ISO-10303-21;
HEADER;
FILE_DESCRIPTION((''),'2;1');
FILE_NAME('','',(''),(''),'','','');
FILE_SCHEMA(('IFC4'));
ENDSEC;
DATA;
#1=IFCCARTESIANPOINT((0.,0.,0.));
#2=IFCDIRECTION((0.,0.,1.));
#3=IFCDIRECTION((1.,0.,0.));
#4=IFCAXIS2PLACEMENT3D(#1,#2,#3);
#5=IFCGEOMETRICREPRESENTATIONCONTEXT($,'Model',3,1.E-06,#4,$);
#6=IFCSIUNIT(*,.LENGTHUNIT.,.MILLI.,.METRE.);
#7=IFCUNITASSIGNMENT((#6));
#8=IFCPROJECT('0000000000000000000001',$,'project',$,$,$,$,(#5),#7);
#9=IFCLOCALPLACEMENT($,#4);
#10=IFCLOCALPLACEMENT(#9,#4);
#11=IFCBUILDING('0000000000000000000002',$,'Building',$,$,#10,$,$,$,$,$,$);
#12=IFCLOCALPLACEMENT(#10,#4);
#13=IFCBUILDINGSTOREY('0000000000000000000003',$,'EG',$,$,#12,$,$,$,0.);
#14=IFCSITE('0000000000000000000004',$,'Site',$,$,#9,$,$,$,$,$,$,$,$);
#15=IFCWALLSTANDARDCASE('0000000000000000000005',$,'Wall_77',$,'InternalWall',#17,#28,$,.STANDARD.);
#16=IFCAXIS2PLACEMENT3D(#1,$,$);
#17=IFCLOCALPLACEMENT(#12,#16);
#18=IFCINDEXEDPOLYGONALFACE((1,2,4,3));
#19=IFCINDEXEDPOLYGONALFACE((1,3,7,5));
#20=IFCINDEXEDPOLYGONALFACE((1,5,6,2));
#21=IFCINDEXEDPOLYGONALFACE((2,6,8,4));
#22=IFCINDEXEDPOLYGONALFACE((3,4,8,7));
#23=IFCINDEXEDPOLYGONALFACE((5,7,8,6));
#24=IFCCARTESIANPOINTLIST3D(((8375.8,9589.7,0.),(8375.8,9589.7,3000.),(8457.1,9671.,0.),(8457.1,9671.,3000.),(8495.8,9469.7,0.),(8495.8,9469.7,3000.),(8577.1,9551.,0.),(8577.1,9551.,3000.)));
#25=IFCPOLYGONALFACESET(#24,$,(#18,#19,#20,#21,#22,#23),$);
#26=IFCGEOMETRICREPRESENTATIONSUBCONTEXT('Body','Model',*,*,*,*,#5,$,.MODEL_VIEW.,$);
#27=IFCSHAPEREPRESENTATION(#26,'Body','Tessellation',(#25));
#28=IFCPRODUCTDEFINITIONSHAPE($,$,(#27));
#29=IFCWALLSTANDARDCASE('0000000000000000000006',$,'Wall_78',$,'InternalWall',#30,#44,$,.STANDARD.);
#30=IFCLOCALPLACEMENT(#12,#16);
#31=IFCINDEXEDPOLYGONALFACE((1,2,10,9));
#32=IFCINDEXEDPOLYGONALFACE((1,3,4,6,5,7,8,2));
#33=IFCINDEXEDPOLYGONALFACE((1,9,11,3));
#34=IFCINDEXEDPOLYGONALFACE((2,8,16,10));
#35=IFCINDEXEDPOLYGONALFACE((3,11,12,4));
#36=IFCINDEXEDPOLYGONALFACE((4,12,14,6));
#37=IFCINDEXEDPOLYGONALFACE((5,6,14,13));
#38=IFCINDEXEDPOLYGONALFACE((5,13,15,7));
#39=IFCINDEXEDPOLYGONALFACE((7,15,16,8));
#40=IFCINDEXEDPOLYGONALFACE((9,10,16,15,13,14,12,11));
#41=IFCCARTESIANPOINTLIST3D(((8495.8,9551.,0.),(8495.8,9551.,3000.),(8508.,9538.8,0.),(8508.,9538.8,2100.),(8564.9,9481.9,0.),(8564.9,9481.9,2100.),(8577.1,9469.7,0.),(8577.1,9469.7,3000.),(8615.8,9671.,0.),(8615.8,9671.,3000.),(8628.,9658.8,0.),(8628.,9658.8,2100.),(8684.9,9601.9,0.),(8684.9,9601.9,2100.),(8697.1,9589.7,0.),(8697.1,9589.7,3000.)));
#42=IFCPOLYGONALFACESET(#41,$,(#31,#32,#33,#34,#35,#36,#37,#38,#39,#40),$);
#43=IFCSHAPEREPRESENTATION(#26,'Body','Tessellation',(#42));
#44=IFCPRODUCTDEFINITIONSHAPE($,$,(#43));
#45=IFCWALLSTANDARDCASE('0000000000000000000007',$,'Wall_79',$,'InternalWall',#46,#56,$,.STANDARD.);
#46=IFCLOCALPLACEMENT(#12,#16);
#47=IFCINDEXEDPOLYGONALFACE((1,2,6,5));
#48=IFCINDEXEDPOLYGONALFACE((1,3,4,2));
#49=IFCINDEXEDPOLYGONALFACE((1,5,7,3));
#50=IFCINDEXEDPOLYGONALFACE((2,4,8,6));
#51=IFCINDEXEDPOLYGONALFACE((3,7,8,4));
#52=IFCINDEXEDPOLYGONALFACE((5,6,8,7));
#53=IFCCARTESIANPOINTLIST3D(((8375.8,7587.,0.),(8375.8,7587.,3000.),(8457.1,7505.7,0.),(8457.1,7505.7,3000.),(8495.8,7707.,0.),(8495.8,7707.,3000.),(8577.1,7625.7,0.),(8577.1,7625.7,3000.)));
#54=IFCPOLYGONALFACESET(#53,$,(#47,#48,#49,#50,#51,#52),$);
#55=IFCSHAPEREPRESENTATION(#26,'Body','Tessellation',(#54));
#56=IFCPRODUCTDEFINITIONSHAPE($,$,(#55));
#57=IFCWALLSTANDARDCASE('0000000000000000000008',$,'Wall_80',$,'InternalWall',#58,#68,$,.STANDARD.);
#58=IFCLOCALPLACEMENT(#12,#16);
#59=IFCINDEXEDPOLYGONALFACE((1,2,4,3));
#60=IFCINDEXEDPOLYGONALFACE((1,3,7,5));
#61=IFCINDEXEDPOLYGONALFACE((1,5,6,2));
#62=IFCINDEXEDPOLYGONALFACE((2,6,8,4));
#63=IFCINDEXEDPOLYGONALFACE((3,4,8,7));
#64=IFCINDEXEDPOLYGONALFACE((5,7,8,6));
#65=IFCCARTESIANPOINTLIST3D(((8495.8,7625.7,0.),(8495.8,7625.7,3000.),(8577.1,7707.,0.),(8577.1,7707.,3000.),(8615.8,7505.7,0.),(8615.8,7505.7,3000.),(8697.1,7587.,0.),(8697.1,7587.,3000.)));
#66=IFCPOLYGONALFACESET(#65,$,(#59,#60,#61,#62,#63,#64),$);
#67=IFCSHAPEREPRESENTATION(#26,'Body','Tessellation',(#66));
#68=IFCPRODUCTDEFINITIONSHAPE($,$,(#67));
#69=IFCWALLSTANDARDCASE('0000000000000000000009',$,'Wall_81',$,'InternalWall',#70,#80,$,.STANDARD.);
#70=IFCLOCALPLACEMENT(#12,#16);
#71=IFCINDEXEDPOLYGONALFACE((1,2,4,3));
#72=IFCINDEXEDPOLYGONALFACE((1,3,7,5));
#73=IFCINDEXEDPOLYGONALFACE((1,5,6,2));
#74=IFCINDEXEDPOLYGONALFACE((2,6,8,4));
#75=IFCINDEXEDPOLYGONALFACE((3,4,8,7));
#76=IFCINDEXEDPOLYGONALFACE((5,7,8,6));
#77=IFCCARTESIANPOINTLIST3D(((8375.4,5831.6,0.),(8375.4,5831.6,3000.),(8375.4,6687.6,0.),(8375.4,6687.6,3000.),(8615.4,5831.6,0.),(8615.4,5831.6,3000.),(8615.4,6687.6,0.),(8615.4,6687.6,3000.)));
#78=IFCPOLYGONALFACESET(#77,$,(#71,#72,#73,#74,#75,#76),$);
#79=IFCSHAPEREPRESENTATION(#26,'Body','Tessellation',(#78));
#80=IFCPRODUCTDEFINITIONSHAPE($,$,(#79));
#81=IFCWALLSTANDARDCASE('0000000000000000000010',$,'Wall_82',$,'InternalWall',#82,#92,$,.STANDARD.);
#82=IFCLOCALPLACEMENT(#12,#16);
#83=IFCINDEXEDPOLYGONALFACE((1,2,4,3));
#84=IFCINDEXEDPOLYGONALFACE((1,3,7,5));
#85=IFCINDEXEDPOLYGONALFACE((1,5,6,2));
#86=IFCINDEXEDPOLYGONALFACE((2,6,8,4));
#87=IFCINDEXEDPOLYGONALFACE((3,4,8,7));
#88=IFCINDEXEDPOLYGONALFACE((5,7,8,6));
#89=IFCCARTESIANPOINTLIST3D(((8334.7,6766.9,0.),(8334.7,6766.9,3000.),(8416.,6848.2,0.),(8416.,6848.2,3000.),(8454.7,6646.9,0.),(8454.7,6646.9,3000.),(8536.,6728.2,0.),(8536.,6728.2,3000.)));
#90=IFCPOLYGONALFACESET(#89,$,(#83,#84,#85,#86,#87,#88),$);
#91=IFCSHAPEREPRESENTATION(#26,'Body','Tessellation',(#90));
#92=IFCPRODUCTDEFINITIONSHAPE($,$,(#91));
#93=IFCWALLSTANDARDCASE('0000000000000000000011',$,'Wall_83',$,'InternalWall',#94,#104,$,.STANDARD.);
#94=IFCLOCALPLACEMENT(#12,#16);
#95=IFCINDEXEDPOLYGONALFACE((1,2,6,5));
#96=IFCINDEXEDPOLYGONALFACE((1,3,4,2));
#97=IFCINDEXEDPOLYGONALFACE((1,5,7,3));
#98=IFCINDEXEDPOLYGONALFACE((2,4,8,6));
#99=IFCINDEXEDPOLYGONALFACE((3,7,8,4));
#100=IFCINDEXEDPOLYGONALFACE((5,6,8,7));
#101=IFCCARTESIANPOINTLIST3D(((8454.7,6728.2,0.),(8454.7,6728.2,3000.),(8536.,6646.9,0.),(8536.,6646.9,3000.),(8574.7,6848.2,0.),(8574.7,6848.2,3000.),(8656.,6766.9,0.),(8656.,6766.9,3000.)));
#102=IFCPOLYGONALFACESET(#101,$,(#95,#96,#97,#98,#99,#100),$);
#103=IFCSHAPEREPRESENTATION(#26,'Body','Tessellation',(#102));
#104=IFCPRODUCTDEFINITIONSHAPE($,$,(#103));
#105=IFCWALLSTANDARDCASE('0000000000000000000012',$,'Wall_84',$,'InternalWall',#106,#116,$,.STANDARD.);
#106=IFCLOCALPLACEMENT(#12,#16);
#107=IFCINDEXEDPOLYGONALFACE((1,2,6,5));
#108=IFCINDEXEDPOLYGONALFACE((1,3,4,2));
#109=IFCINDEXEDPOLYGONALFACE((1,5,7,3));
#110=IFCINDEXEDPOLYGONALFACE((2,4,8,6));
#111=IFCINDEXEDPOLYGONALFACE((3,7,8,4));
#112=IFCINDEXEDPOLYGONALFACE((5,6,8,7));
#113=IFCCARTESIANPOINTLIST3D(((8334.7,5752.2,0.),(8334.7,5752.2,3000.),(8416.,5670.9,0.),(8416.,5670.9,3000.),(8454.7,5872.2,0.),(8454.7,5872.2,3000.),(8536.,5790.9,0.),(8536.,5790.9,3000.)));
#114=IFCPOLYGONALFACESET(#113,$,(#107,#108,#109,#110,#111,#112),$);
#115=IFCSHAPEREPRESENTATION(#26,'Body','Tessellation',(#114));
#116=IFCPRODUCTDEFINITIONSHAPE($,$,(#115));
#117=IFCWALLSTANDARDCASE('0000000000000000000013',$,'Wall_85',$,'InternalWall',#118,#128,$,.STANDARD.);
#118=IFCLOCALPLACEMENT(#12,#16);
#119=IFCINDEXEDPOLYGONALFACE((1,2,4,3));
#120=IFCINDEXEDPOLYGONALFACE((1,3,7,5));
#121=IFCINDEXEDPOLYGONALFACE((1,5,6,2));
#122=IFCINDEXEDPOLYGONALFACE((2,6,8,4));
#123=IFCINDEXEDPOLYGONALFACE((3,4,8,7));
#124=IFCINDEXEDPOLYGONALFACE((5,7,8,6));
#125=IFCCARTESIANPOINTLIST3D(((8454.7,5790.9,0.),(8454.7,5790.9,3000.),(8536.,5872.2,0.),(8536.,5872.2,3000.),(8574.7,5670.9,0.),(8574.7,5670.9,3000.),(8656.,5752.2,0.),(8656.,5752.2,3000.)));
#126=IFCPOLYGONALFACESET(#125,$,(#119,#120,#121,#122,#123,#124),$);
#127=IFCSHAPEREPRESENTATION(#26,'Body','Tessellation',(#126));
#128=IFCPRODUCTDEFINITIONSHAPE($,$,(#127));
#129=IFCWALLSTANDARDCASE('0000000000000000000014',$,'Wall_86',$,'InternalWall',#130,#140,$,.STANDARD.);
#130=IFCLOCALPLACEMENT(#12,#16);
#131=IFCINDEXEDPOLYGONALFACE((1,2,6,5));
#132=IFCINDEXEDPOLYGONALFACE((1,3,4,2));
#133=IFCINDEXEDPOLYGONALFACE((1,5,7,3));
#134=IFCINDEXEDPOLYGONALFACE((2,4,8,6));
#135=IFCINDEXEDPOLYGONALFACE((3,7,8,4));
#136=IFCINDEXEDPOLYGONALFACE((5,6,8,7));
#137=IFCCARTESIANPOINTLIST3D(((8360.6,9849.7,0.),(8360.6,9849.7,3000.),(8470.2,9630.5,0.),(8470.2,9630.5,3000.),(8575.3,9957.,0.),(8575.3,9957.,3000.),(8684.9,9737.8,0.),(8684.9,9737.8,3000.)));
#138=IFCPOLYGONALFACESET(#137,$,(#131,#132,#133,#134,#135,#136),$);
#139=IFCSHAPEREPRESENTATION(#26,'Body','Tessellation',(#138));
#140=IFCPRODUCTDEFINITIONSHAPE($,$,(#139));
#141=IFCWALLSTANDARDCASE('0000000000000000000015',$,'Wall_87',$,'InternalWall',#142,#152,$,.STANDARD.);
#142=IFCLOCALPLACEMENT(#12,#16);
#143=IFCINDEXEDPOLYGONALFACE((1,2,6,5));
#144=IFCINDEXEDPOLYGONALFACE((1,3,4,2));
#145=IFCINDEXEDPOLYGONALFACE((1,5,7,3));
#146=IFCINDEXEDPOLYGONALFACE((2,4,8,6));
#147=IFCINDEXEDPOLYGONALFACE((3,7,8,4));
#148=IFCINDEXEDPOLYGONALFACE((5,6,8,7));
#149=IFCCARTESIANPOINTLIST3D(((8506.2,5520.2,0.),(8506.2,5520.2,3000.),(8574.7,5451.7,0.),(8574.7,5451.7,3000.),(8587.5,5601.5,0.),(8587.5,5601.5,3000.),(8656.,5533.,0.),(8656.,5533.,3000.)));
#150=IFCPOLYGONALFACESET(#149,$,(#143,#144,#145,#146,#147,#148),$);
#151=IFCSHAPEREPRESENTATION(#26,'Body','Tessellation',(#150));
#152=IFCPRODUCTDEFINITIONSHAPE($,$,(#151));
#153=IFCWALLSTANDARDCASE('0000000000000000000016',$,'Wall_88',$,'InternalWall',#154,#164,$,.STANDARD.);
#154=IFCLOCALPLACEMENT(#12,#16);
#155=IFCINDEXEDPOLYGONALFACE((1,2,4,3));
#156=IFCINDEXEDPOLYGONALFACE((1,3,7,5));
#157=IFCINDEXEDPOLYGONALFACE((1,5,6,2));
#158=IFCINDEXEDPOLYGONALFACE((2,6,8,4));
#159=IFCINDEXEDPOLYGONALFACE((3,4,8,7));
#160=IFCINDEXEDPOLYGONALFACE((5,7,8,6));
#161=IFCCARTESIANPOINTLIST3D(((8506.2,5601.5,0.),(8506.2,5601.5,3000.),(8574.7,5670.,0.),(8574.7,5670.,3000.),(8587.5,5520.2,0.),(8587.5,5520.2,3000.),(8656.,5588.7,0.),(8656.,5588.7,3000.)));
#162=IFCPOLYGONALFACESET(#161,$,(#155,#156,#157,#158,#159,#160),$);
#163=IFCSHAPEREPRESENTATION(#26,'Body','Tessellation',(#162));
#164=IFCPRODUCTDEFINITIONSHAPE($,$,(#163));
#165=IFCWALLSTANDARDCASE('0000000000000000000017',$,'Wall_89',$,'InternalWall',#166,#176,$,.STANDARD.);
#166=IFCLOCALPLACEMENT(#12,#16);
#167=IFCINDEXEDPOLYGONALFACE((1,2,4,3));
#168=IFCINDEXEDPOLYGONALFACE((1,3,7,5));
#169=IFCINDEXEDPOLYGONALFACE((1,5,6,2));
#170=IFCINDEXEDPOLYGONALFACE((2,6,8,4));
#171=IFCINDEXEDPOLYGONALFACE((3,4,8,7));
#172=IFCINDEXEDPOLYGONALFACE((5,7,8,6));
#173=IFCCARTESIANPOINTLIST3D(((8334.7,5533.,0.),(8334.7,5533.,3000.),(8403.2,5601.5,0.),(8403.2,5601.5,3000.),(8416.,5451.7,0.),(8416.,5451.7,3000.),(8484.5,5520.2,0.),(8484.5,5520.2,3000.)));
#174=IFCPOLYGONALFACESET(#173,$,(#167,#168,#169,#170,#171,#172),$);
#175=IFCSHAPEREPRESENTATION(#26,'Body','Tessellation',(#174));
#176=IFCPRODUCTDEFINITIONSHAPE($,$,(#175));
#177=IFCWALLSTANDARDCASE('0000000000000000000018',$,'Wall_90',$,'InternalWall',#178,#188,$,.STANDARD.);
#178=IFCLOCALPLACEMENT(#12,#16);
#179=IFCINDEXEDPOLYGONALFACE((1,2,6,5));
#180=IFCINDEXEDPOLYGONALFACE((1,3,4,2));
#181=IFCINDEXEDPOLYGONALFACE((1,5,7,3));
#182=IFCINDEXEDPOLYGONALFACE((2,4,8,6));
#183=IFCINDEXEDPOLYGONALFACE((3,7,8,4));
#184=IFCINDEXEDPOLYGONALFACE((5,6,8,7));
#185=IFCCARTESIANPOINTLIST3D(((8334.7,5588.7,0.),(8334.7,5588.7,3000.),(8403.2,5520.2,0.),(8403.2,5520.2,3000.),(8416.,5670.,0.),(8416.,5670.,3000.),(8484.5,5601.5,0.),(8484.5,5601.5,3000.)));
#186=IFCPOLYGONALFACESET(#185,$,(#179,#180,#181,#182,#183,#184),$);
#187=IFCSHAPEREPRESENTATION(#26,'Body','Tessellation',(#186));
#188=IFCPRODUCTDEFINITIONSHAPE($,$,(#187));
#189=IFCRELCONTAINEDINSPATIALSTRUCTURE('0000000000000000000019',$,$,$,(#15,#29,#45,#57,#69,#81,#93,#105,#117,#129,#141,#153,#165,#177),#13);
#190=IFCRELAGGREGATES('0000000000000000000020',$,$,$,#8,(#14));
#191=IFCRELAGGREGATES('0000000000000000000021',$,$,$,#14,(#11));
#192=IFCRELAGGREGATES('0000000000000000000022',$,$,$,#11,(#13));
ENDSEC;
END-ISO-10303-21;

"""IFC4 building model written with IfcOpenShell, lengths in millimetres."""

from ifc_helpers import new_model, si_unit, frame, origin_with_axes, place, context, subcontext, project, spatial, rectangle, extrude, element, save


model = new_model("IFC4")

# Units and contexts
model_context = context("Model", 3, precision=1e-06, world=origin_with_axes())
body_context = subcontext(model_context, "Body", "Model", "MODEL_VIEW")
ifc_project = project(units=[si_unit("LENGTHUNIT", "METRE", prefix="MILLI")], contexts=[model_context])

# Site, building, storey
site_placement = place(None, origin_with_axes())
site = spatial("IfcSite", under=ifc_project, at=site_placement, Name="Site")
building_placement = place(site_placement, origin_with_axes())
building = spatial("IfcBuilding", under=site, at=building_placement, Name="Building")
storey_placement = place(building_placement, origin_with_axes())
storey = spatial("IfcBuildingStorey", under=building, at=storey_placement, Name="EG", Elevation=0.0)

# Wall
wall_1_placement = place(storey_placement, origin_with_axes())
element("IfcWallStandardCase", 1, at=wall_1_placement, inside=storey, Name="Wall_77", ObjectType="InternalWall", PredefinedType="STANDARD", context=body_context, shape_type="SweptSolid", body=[
    extrude(rectangle(XDim=169.7, YDim=115.0), frame((8476.5, 9570.4, 0.0), z_axis=(0.0, 0.0, 1.0), x_axis=(-0.707107, 0.707107, 0.0)), (0.0, 0.0, 1.0), 3000.0),
])

# Wall, opening
wall_2_placement = place(storey_placement, origin_with_axes())
wall_2 = element("IfcWallStandardCase", 2, at=wall_2_placement, inside=storey, Name="Wall_78", ObjectType="InternalWall", PredefinedType="STANDARD", context=body_context, shape_type="SweptSolid", body=[
    extrude(rectangle(XDim=169.7, YDim=115.0), frame((8596.5, 9570.4, 0.0), z_axis=(0.0, 0.0, 1.0), x_axis=(0.707107, 0.707107, 0.0)), (0.0, 0.0, 1.0), 3000.0),
])
opening_1_placement = place(wall_2_placement, origin_with_axes())
element("IfcOpeningElement", 3, at=opening_1_placement, inside=storey, cuts=wall_2, context=body_context, shape_type="SweptSolid", body=[
    extrude(rectangle(XDim=1067.6, YDim=80.5), frame((8894.2, 9868.0, 0.0), z_axis=(0.0, 0.0, 1.0), x_axis=(0.707107, 0.707107, 0.0)), (0.0, 0.0, 1.0), 2100.0),
])

# Walls
wall_3_placement = place(storey_placement, origin_with_axes())
element("IfcWallStandardCase", 4, at=wall_3_placement, inside=storey, Name="Wall_79", ObjectType="InternalWall", PredefinedType="STANDARD", context=body_context, shape_type="SweptSolid", body=[
    extrude(rectangle(XDim=169.7, YDim=115.0), frame((8476.5, 7606.4, 0.0), z_axis=(0.0, 0.0, 1.0), x_axis=(-0.707107, -0.707107, 0.0)), (0.0, 0.0, 1.0), 3000.0),
])
wall_4_placement = place(storey_placement, origin_with_axes())
element("IfcWallStandardCase", 5, at=wall_4_placement, inside=storey, Name="Wall_80", ObjectType="InternalWall", PredefinedType="STANDARD", context=body_context, shape_type="SweptSolid", body=[
    extrude(rectangle(XDim=169.7, YDim=115.0), frame((8596.5, 7606.4, 0.0), z_axis=(0.0, 0.0, 1.0), x_axis=(0.707107, -0.707107, 0.0)), (0.0, 0.0, 1.0), 3000.0),
])
wall_5_placement = place(storey_placement, origin_with_axes())
element("IfcWallStandardCase", 6, at=wall_5_placement, inside=storey, Name="Wall_81", ObjectType="InternalWall", PredefinedType="STANDARD", context=body_context, shape_type="SweptSolid", body=[
    extrude(rectangle(XDim=856.0, YDim=240.0), frame((8495.4, 6259.6, 0.0), z_axis=(0.0, 0.0, 1.0), x_axis=(0.0, -1.0, 0.0)), (0.0, 0.0, 1.0), 3000.0),
])
wall_6_placement = place(storey_placement, origin_with_axes())
element("IfcWallStandardCase", 7, at=wall_6_placement, inside=storey, Name="Wall_82", ObjectType="InternalWall", PredefinedType="STANDARD", context=body_context, shape_type="SweptSolid", body=[
    extrude(rectangle(XDim=169.7, YDim=115.0), frame((8435.4, 6747.6, 0.0), z_axis=(0.0, 0.0, 1.0), x_axis=(-0.707107, 0.707107, 0.0)), (0.0, 0.0, 1.0), 3000.0),
])
wall_7_placement = place(storey_placement, origin_with_axes())
element("IfcWallStandardCase", 8, at=wall_7_placement, inside=storey, Name="Wall_83", ObjectType="InternalWall", PredefinedType="STANDARD", context=body_context, shape_type="SweptSolid", body=[
    extrude(rectangle(XDim=169.7, YDim=115.0), frame((8555.4, 6747.6, 0.0), z_axis=(0.0, 0.0, 1.0), x_axis=(0.707107, 0.707107, 0.0)), (0.0, 0.0, 1.0), 3000.0),
])
wall_8_placement = place(storey_placement, origin_with_axes())
element("IfcWallStandardCase", 9, at=wall_8_placement, inside=storey, Name="Wall_84", ObjectType="InternalWall", PredefinedType="STANDARD", context=body_context, shape_type="SweptSolid", body=[
    extrude(rectangle(XDim=169.7, YDim=115.0), frame((8435.4, 5771.6, 0.0), z_axis=(0.0, 0.0, 1.0), x_axis=(-0.707107, -0.707107, 0.0)), (0.0, 0.0, 1.0), 3000.0),
])
wall_9_placement = place(storey_placement, origin_with_axes())
element("IfcWallStandardCase", 10, at=wall_9_placement, inside=storey, Name="Wall_85", ObjectType="InternalWall", PredefinedType="STANDARD", context=body_context, shape_type="SweptSolid", body=[
    extrude(rectangle(XDim=169.7, YDim=115.0), frame((8555.4, 5771.6, 0.0), z_axis=(0.0, 0.0, 1.0), x_axis=(0.707107, -0.707107, 0.0)), (0.0, 0.0, 1.0), 3000.0),
])
wall_10_placement = place(storey_placement, origin_with_axes())
element("IfcWallStandardCase", 11, at=wall_10_placement, inside=storey, Name="Wall_86", ObjectType="InternalWall", PredefinedType="STANDARD", context=body_context, shape_type="SweptSolid", body=[
    extrude(rectangle(XDim=245.0, YDim=240.0), frame((8522.8, 9793.8, 0.0), z_axis=(0.0, 0.0, 1.0), x_axis=(-0.447214, 0.894427, 0.0)), (0.0, 0.0, 1.0), 3000.0),
])
wall_11_placement = place(storey_placement, origin_with_axes())
element("IfcWallStandardCase", 12, at=wall_11_placement, inside=storey, Name="Wall_87", ObjectType="InternalWall", PredefinedType="STANDARD", context=body_context, shape_type="SweptSolid", body=[
    extrude(rectangle(XDim=96.9, YDim=115.0), frame((8581.1, 5526.6, 0.0), z_axis=(0.0, 0.0, 1.0), x_axis=(0.707107, -0.707107, 0.0)), (0.0, 0.0, 1.0), 3000.0),
])
wall_12_placement = place(storey_placement, origin_with_axes())
element("IfcWallStandardCase", 13, at=wall_12_placement, inside=storey, Name="Wall_88", ObjectType="InternalWall", PredefinedType="STANDARD", context=body_context, shape_type="SweptSolid", body=[
    extrude(rectangle(XDim=96.9, YDim=115.0), frame((8581.1, 5595.1, 0.0), z_axis=(0.0, 0.0, 1.0), x_axis=(0.707107, 0.707107, 0.0)), (0.0, 0.0, 1.0), 3000.0),
])
wall_13_placement = place(storey_placement, origin_with_axes())
element("IfcWallStandardCase", 14, at=wall_13_placement, inside=storey, Name="Wall_89", ObjectType="InternalWall", PredefinedType="STANDARD", context=body_context, shape_type="SweptSolid", body=[
    extrude(rectangle(XDim=96.9, YDim=115.0), frame((8409.6, 5526.6, 0.0), z_axis=(0.0, 0.0, 1.0), x_axis=(-0.707107, -0.707107, 0.0)), (0.0, 0.0, 1.0), 3000.0),
])
wall_14_placement = place(storey_placement, origin_with_axes())
element("IfcWallStandardCase", 15, at=wall_14_placement, inside=storey, Name="Wall_90", ObjectType="InternalWall", PredefinedType="STANDARD", context=body_context, shape_type="SweptSolid", body=[
    extrude(rectangle(XDim=96.9, YDim=115.0), frame((8409.6, 5595.1, 0.0), z_axis=(0.0, 0.0, 1.0), x_axis=(-0.707107, 0.707107, 0.0)), (0.0, 0.0, 1.0), 3000.0),
])

save(model, "model.ifc")
